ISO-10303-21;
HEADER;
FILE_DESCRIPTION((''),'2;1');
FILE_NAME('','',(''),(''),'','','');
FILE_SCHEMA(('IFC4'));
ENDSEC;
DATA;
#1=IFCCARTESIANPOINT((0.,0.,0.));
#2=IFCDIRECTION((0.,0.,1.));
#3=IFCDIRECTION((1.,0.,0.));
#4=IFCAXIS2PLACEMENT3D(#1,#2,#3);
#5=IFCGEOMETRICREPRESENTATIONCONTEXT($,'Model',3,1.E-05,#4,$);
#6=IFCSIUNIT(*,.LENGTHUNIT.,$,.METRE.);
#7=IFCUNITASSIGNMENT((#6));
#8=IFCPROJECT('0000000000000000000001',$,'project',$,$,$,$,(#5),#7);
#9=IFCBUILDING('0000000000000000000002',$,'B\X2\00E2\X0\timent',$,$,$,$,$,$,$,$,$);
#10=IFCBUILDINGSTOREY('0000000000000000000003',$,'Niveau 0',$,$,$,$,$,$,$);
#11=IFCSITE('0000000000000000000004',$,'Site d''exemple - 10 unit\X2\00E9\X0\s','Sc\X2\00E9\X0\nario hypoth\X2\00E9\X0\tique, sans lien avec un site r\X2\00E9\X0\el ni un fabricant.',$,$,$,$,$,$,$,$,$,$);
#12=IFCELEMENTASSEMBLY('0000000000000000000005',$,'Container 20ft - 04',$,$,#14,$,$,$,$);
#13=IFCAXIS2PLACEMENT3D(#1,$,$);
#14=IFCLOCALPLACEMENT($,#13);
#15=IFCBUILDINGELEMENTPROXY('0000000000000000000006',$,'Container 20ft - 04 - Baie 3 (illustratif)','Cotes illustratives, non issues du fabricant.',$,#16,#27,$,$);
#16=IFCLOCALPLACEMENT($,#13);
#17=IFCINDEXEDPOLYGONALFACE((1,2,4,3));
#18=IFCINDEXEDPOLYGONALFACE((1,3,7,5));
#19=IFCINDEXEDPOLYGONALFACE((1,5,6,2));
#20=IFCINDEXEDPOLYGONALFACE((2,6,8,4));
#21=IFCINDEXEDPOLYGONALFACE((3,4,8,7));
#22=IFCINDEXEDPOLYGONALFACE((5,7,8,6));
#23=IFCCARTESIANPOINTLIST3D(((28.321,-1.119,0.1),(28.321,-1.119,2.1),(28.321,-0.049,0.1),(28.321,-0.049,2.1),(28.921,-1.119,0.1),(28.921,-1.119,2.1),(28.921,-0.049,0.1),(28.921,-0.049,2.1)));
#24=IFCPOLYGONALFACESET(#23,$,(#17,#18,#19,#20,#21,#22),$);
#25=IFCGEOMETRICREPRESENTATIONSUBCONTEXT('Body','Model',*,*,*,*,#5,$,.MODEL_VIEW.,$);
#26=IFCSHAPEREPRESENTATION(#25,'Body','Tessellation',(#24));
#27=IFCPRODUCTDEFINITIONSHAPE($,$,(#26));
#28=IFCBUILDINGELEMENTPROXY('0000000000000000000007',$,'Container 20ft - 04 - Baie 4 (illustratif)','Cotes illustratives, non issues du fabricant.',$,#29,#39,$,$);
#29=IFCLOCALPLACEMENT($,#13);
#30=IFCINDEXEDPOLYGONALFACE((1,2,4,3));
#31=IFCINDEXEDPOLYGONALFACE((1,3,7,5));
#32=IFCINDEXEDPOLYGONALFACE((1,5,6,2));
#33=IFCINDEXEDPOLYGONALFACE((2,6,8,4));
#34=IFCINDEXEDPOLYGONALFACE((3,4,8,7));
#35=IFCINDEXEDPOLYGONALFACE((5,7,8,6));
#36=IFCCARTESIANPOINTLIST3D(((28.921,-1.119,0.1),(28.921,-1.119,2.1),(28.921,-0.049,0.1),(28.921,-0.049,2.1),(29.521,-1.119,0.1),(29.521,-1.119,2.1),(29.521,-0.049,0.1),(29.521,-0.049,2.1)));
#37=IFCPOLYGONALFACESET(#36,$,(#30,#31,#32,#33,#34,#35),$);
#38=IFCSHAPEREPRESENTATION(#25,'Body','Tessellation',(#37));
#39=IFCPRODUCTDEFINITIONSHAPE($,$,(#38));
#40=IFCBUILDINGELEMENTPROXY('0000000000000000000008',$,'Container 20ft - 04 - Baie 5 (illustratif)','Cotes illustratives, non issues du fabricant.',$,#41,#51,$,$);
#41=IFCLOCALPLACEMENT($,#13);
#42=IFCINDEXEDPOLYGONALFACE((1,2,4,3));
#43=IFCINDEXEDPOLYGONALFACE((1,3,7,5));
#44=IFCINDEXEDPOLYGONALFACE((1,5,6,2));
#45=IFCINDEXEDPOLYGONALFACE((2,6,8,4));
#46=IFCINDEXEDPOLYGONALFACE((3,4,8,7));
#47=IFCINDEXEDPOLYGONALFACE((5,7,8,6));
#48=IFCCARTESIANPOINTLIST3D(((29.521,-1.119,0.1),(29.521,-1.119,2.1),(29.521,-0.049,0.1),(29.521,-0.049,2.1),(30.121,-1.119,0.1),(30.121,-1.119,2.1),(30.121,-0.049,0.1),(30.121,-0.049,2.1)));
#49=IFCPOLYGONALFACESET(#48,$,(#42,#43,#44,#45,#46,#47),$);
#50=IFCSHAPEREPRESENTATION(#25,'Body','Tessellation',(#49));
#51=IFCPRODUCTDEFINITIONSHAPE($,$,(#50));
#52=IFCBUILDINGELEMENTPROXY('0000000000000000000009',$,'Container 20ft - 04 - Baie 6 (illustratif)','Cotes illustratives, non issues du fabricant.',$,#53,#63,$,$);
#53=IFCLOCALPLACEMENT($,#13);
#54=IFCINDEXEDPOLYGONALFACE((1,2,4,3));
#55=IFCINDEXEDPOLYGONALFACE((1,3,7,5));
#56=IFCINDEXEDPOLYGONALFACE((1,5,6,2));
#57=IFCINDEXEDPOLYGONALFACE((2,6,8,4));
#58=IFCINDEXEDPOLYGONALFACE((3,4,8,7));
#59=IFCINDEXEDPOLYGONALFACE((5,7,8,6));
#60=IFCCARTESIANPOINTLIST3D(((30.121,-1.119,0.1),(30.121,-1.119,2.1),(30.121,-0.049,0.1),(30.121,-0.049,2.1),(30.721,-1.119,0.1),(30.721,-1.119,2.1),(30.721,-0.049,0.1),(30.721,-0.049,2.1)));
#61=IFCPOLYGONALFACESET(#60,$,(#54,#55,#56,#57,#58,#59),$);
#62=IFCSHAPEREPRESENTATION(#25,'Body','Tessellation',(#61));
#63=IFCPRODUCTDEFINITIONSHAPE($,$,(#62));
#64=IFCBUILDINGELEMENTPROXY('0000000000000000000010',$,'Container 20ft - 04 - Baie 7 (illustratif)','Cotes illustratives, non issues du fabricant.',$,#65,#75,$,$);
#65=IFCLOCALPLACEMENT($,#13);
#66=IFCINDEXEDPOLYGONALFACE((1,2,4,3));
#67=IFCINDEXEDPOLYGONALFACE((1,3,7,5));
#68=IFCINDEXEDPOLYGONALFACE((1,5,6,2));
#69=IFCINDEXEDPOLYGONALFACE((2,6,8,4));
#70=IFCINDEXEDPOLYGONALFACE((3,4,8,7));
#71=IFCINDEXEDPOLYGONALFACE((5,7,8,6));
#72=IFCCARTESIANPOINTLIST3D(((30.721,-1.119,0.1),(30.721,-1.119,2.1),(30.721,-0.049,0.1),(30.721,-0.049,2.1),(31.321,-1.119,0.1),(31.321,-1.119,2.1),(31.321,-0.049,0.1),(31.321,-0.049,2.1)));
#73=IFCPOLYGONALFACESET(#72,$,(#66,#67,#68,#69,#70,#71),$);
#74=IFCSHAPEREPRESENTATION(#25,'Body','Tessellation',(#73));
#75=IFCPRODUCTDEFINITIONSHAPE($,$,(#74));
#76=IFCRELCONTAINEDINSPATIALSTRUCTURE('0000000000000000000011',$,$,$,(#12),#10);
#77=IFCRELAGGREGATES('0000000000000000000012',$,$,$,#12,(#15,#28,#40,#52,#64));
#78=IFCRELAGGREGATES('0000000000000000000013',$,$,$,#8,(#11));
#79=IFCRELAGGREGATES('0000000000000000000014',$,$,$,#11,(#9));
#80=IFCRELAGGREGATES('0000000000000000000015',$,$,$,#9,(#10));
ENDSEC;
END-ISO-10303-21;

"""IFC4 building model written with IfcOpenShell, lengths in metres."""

from ifc_helpers import new_model, si_unit, frame, origin_with_axes, place, context, subcontext, project, spatial, rectangle, extrude, element, aggregate, save


model = new_model("IFC4")

# Units and contexts
model_context = context("Model", 3, precision=1e-05, world=origin_with_axes())
body_context = subcontext(model_context, "Body", "Model", "MODEL_VIEW")
ifc_project = project(units=[si_unit("LENGTHUNIT", "METRE")], contexts=[model_context])

# Site, building, storey
site = spatial("IfcSite", under=ifc_project, Name="Site d'exemple - 10 unités", Description="Scénario hypothétique, sans lien avec un site réel ni un fabricant.")
building = spatial("IfcBuilding", under=site, Name="Bâtiment")
storey = spatial("IfcBuildingStorey", under=building, Name="Niveau 0")

# Element assembly, building element proxies
assembly = element("IfcElementAssembly", 1, inside=storey, Name="Container 20ft - 04")
proxy_1_placement = place(None, frame((28.621, -0.584, 0.1), z_axis=(0.0, 0.0, 1.0), x_axis=(1.0, 0.0, 0.0)))
proxy_1 = element("IfcBuildingElementProxy", 2, at=proxy_1_placement, Name="Container 20ft - 04 - Baie 3 (illustratif)", Description="Cotes illustratives, non issues du fabricant.", context=body_context, shape_type="SweptSolid", body=[
    extrude(rectangle(XDim=0.6, YDim=1.07), origin_with_axes(), (0.0, 0.0, 1.0), 2.0),
])
proxy_2_placement = place(None, frame((29.221, -0.584, 0.1), z_axis=(0.0, 0.0, 1.0), x_axis=(1.0, 0.0, 0.0)))
proxy_2 = element("IfcBuildingElementProxy", 3, at=proxy_2_placement, Name="Container 20ft - 04 - Baie 4 (illustratif)", Description="Cotes illustratives, non issues du fabricant.", context=body_context, shape_type="SweptSolid", body=[
    extrude(rectangle(XDim=0.6, YDim=1.07), origin_with_axes(), (0.0, 0.0, 1.0), 2.0),
])
proxy_3_placement = place(None, frame((29.821, -0.584, 0.1), z_axis=(0.0, 0.0, 1.0), x_axis=(1.0, 0.0, 0.0)))
proxy_3 = element("IfcBuildingElementProxy", 4, at=proxy_3_placement, Name="Container 20ft - 04 - Baie 5 (illustratif)", Description="Cotes illustratives, non issues du fabricant.", context=body_context, shape_type="SweptSolid", body=[
    extrude(rectangle(XDim=0.6, YDim=1.07), origin_with_axes(), (0.0, 0.0, 1.0), 2.0),
])
proxy_4_placement = place(None, frame((30.421, -0.584, 0.1), z_axis=(0.0, 0.0, 1.0), x_axis=(1.0, 0.0, 0.0)))
proxy_4 = element("IfcBuildingElementProxy", 5, at=proxy_4_placement, Name="Container 20ft - 04 - Baie 6 (illustratif)", Description="Cotes illustratives, non issues du fabricant.", context=body_context, shape_type="SweptSolid", body=[
    extrude(rectangle(XDim=0.6, YDim=1.07), origin_with_axes(), (0.0, 0.0, 1.0), 2.0),
])
proxy_5_placement = place(None, frame((31.021, -0.584, 0.1), z_axis=(0.0, 0.0, 1.0), x_axis=(1.0, 0.0, 0.0)))
proxy_5 = element("IfcBuildingElementProxy", 6, at=proxy_5_placement, Name="Container 20ft - 04 - Baie 7 (illustratif)", Description="Cotes illustratives, non issues du fabricant.", context=body_context, shape_type="SweptSolid", body=[
    extrude(rectangle(XDim=0.6, YDim=1.07), origin_with_axes(), (0.0, 0.0, 1.0), 2.0),
])
aggregate(assembly, [proxy_1, proxy_2, proxy_3, proxy_4, proxy_5])

save(model, "model.ifc")
